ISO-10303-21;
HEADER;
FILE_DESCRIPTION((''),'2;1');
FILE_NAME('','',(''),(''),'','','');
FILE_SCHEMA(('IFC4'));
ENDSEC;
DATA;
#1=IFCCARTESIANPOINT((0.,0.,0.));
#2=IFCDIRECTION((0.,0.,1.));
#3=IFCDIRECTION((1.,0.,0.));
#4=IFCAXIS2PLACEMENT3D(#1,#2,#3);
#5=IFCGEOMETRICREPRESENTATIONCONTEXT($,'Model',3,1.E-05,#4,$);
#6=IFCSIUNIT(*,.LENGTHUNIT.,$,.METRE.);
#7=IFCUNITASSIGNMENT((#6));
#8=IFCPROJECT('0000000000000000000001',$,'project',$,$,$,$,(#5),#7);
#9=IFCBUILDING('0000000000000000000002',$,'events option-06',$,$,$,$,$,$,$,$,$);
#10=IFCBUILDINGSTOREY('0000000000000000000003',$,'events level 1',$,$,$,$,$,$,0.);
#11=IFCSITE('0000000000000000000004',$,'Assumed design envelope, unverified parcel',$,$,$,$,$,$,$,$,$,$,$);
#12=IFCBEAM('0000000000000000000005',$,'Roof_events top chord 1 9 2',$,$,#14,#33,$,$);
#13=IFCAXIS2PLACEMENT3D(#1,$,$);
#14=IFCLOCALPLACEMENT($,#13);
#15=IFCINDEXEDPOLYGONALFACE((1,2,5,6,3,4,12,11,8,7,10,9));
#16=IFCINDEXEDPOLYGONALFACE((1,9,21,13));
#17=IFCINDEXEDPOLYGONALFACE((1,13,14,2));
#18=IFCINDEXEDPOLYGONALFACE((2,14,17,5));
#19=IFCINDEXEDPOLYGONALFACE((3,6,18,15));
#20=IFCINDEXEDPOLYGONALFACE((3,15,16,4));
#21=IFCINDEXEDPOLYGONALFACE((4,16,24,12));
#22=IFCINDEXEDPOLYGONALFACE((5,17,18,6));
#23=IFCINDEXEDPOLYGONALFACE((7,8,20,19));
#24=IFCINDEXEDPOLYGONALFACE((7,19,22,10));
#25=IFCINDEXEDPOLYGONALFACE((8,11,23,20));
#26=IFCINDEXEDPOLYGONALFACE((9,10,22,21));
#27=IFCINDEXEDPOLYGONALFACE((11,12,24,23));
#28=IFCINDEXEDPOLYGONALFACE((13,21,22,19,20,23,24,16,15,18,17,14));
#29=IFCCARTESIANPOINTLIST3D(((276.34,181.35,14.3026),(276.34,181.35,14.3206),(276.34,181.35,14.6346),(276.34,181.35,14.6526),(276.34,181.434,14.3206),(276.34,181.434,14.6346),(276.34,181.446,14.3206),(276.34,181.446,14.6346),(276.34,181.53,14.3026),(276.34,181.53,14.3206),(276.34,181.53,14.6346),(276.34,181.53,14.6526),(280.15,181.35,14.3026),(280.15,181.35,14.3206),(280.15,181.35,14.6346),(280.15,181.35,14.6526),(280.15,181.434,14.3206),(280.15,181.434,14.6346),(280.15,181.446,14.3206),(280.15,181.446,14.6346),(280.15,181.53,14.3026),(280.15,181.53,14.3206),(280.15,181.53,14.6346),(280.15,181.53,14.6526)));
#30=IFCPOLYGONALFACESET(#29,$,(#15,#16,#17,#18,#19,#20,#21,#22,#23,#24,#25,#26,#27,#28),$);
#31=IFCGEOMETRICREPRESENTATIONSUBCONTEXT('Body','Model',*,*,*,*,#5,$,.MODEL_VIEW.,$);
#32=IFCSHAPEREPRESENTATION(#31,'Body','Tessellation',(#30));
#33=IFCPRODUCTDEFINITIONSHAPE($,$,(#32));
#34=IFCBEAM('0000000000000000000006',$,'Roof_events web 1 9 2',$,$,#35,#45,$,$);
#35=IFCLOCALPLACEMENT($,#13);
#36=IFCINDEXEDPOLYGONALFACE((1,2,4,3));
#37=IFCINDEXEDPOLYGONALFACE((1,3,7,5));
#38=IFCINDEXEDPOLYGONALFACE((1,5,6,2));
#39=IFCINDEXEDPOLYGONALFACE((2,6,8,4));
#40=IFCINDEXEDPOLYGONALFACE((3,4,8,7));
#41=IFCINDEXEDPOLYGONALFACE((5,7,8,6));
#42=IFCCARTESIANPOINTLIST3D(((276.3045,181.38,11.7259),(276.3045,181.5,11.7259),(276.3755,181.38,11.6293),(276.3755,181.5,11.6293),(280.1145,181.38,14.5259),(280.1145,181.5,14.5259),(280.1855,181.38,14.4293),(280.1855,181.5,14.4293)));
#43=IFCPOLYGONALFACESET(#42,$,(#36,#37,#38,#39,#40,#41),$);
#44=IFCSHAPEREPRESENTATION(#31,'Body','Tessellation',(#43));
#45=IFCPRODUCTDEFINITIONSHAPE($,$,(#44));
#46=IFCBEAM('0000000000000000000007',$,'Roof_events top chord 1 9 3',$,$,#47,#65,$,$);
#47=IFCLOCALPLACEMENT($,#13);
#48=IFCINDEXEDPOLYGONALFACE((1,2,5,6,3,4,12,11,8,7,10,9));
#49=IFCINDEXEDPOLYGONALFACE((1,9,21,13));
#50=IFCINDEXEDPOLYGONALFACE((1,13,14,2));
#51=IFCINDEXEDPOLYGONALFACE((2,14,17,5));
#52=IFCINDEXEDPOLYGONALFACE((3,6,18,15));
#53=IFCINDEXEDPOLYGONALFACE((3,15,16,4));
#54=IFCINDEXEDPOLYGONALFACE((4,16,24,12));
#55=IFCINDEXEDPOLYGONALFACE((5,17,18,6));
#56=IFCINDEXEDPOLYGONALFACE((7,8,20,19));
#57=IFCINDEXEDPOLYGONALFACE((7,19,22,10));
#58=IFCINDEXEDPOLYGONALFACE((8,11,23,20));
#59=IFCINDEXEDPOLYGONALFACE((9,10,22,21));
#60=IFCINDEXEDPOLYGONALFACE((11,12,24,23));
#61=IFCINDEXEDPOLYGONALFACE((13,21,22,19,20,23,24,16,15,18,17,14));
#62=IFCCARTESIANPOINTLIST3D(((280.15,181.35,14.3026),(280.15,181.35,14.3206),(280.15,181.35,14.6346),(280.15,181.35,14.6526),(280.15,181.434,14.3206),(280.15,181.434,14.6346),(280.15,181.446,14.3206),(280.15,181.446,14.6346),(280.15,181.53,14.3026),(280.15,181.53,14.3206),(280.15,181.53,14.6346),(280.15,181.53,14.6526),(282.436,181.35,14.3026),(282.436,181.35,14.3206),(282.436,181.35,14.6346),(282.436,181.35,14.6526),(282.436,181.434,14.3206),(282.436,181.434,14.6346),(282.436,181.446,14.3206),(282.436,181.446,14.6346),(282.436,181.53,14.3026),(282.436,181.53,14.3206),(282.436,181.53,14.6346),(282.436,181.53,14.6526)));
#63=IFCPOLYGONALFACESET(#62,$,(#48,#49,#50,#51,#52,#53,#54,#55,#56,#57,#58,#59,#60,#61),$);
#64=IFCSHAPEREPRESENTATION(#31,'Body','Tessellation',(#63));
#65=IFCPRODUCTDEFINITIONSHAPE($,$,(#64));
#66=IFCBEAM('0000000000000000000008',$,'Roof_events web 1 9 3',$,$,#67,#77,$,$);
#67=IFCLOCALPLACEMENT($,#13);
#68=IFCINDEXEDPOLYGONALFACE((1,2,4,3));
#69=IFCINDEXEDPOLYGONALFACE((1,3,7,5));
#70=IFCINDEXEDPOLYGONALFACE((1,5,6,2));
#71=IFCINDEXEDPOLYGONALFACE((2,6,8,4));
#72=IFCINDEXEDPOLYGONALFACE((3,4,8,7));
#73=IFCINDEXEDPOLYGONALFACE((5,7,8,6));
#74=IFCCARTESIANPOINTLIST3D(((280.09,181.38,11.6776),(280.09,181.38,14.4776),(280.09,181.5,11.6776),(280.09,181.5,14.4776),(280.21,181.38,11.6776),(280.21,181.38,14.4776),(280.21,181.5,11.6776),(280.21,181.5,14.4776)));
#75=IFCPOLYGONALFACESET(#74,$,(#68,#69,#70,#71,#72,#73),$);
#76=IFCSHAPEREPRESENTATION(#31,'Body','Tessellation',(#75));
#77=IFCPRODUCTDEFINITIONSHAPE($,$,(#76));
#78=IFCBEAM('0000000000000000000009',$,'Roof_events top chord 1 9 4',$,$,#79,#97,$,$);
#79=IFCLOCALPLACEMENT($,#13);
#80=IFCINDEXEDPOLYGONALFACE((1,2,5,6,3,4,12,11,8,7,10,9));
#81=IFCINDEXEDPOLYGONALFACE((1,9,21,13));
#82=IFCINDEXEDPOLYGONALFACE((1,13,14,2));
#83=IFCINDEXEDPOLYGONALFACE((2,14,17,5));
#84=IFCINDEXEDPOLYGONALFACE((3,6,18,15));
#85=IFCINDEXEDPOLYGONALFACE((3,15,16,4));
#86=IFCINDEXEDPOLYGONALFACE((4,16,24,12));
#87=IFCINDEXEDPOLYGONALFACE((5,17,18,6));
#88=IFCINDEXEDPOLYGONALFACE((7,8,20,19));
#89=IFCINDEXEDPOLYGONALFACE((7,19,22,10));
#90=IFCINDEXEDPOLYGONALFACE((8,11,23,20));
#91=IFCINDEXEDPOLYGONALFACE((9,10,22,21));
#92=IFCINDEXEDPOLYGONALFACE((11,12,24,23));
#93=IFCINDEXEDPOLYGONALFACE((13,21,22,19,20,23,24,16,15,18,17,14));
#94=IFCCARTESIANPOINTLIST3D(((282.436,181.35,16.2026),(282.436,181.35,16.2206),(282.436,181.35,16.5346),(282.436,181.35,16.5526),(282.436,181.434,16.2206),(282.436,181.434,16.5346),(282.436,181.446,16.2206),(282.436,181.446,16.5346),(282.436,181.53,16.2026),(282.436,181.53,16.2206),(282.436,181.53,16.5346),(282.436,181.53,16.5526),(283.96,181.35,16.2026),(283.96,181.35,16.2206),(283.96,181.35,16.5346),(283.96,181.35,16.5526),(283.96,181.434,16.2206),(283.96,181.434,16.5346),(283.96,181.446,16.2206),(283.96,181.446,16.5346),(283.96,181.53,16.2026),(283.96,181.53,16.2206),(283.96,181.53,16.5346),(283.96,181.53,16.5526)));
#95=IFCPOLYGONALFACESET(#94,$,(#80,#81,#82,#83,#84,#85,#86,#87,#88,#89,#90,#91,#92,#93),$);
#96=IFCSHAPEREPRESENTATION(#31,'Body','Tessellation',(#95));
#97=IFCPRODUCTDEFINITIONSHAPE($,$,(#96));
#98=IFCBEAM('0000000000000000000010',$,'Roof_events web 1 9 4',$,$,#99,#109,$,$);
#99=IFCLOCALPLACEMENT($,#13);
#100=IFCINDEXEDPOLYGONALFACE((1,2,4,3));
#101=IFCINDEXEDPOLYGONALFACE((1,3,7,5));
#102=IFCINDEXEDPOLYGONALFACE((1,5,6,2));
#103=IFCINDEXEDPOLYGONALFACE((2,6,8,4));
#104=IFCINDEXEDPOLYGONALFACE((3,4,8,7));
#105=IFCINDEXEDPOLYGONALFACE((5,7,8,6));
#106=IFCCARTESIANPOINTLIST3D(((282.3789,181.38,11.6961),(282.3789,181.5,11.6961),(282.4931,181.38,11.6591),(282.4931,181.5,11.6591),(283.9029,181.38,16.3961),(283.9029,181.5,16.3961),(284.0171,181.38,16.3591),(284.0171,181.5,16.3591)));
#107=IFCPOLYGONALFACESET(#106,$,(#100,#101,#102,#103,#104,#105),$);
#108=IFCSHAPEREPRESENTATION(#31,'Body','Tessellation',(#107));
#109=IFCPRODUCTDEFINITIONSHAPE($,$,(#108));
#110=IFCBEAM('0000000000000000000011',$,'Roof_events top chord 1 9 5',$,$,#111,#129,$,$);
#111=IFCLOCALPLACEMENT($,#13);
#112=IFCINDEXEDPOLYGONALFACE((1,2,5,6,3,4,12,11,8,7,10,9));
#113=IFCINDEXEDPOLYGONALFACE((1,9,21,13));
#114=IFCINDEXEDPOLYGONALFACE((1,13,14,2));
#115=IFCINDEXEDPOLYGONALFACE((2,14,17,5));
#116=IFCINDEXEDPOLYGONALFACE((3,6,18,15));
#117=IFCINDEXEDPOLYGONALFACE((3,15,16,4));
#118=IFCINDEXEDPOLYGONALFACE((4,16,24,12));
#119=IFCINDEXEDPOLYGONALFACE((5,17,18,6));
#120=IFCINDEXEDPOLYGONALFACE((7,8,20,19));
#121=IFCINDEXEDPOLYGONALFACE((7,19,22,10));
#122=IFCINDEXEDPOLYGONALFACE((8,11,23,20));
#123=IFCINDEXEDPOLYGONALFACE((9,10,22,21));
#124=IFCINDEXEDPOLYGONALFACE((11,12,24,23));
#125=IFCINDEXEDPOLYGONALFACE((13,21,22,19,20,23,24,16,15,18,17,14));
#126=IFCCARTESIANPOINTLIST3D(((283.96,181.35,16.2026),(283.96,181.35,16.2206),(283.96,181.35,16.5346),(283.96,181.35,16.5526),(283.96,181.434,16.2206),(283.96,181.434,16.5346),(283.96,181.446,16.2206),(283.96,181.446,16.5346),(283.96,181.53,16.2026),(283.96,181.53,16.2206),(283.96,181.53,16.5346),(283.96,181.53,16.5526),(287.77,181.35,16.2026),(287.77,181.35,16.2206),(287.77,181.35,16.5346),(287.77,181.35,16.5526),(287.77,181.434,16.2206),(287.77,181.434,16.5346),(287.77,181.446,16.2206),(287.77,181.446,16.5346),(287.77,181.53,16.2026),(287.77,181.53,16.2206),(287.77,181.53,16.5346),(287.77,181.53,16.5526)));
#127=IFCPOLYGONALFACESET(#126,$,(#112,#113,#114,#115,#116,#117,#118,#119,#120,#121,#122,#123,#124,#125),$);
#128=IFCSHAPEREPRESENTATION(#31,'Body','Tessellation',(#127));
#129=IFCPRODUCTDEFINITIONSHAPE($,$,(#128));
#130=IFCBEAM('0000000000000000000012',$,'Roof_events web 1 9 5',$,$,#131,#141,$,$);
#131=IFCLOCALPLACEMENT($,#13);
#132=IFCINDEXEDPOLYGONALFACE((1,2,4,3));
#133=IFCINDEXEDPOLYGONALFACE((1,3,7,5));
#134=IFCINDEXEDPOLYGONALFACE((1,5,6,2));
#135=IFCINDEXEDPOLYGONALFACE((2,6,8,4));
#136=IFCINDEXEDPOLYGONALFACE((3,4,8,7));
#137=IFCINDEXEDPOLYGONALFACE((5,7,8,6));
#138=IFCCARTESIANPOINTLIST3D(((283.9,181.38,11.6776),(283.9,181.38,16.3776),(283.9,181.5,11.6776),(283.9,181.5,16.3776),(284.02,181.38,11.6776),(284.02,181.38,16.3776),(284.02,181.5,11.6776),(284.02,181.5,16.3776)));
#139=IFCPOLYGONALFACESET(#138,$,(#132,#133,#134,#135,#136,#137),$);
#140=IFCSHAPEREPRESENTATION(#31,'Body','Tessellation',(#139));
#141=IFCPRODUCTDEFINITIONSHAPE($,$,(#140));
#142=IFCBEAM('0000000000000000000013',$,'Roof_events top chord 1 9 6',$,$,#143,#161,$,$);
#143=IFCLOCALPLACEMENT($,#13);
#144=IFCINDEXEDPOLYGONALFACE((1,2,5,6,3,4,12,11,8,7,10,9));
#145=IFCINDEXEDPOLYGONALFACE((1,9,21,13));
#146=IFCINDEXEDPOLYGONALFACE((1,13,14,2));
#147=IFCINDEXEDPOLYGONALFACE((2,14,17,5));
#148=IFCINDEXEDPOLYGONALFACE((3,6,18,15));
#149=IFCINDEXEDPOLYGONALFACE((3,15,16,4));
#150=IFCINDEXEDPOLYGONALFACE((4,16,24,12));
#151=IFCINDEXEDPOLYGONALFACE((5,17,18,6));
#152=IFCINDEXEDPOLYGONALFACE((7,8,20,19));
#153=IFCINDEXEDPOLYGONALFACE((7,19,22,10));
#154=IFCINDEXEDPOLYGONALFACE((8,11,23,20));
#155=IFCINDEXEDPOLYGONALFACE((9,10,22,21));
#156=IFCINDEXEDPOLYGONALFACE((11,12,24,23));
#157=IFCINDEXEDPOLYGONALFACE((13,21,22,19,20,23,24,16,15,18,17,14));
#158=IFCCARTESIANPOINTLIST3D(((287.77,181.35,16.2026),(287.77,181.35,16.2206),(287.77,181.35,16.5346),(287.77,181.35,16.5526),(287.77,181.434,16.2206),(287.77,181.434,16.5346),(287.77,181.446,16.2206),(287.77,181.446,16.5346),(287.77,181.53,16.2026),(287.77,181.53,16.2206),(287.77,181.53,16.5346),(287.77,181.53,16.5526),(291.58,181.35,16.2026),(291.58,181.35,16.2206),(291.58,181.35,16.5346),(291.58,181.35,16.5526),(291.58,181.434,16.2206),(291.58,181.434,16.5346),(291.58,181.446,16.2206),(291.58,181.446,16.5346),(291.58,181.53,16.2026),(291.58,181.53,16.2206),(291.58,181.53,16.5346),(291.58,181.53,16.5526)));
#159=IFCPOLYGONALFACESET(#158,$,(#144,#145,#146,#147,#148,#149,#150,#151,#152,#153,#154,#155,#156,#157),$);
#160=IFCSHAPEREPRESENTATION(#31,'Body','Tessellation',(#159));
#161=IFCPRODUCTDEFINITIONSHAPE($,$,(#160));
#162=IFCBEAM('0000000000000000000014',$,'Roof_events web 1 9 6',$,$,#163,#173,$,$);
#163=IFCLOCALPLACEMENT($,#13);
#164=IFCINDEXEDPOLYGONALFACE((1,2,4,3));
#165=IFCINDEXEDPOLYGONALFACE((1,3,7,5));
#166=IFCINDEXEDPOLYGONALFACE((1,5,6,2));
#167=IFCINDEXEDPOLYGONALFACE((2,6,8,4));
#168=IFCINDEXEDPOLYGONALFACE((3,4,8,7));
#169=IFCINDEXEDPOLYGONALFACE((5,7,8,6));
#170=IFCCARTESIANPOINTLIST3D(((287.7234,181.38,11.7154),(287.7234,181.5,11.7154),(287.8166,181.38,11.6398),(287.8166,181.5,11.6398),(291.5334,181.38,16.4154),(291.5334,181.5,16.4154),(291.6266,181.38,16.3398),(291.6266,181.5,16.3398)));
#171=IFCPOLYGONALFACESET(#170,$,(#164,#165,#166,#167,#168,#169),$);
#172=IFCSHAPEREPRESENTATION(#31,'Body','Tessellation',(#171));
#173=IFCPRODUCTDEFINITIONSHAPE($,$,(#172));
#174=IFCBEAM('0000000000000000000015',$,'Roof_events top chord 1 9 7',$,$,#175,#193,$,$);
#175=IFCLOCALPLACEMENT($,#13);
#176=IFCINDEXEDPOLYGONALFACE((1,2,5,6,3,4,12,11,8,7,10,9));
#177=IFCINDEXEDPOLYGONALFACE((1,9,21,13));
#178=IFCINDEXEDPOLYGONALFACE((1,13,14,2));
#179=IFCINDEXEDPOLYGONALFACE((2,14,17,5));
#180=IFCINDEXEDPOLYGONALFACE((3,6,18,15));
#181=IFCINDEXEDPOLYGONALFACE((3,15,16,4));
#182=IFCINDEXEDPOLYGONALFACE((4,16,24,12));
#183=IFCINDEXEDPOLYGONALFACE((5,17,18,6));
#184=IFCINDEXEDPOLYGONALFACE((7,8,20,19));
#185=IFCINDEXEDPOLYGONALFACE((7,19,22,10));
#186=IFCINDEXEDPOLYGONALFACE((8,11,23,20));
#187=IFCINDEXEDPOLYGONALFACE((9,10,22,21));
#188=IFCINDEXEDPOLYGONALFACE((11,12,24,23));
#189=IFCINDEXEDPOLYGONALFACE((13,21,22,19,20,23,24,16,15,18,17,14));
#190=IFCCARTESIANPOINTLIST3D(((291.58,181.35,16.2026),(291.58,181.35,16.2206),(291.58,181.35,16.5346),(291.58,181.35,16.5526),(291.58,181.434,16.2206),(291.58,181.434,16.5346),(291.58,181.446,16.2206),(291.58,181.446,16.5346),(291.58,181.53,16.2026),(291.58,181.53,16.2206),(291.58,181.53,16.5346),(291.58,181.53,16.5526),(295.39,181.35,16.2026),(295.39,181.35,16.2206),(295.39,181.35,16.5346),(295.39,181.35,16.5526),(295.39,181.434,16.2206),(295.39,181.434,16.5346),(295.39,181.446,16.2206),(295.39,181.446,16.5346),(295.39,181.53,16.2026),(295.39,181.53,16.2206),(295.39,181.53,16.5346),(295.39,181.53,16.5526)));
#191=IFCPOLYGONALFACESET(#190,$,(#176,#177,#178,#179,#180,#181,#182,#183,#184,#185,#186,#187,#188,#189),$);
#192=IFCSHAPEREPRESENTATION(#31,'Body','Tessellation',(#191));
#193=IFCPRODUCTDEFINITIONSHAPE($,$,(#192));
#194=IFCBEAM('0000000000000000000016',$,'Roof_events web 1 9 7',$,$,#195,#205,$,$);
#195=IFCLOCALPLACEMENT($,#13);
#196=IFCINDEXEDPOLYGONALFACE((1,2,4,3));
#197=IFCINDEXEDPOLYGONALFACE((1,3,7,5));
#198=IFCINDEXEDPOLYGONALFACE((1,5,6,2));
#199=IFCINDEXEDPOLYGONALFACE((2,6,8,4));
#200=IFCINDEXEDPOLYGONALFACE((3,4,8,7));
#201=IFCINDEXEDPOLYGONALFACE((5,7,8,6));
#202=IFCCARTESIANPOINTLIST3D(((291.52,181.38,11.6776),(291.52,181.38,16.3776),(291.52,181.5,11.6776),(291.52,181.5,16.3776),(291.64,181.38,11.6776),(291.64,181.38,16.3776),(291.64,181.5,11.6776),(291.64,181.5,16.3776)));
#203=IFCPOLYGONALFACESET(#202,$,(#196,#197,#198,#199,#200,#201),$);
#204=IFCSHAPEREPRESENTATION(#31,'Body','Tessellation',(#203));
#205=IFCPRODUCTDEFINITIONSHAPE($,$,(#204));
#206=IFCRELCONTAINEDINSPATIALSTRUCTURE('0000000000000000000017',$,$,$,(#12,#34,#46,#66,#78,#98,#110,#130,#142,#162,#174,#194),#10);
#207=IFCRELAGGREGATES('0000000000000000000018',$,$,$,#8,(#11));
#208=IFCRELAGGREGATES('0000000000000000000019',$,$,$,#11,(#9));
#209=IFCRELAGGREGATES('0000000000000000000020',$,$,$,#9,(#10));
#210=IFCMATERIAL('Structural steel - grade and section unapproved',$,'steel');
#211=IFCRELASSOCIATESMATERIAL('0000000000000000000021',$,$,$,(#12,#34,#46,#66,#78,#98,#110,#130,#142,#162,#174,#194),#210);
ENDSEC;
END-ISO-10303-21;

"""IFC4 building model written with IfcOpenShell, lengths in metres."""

from ifc_helpers import new_model, si_unit, frame, origin_with_axes, place, context, subcontext, project, spatial, rectangle, i_section, extrude, material, element, save


model = new_model("IFC4")

# Units and contexts
model_context = context("Model", 3, precision=1e-05, world=origin_with_axes())
body_context = subcontext(model_context, "Body", "Model", "MODEL_VIEW")
ifc_project = project(units=[si_unit("LENGTHUNIT", "METRE")], contexts=[model_context])

# Site, building, storey
site = spatial("IfcSite", under=ifc_project, Name="Assumed design envelope, unverified parcel")
building = spatial("IfcBuilding", under=site, Name="events option-06")
storey = spatial("IfcBuildingStorey", under=building, Name="events level 1", Elevation=0.0)

# Beams
ifc_material_1 = material(Name="Structural steel - grade and section unapproved", Category="steel")
beam_1_placement = place(None, frame((276.34, 181.44, 14.4776), z_axis=(1.0, 0.0, 0.0), x_axis=(0.0, 1.0, 0.0)))
element("IfcBeam", 1, at=beam_1_placement, inside=storey, material=ifc_material_1, Name="Roof_events top chord 1 9 2", context=body_context, shape_type="SweptSolid", body=[
    extrude(i_section(OverallWidth=0.18, OverallDepth=0.35, WebThickness=0.012, FlangeThickness=0.018, FilletRadius=0.0), origin_with_axes(), (0.0, 0.0, 1.0), 3.81),
])
beam_2_placement = place(None, frame((276.34, 181.44, 11.6776), z_axis=(0.805799, 0.0, 0.592189), x_axis=(0.0, 1.0, 0.0)))
element("IfcBeam", 2, at=beam_2_placement, inside=storey, material=ifc_material_1, Name="Roof_events web 1 9 2", context=body_context, shape_type="SweptSolid", body=[
    extrude(rectangle(XDim=0.12, YDim=0.12), origin_with_axes(), (0.0, 0.0, 1.0), 4.7282),
])
beam_3_placement = place(None, frame((280.15, 181.44, 14.4776), z_axis=(1.0, 0.0, 0.0), x_axis=(0.0, 1.0, 0.0)))
element("IfcBeam", 3, at=beam_3_placement, inside=storey, material=ifc_material_1, Name="Roof_events top chord 1 9 3", context=body_context, shape_type="SweptSolid", body=[
    extrude(i_section(OverallWidth=0.18, OverallDepth=0.35, WebThickness=0.012, FlangeThickness=0.018, FilletRadius=0.0), origin_with_axes(), (0.0, 0.0, 1.0), 2.286),
])
beam_4_placement = place(None, frame((280.15, 181.44, 11.6776), z_axis=(0.0, 0.0, 1.0), x_axis=(-1.0, 0.0, 0.0)))
element("IfcBeam", 4, at=beam_4_placement, inside=storey, material=ifc_material_1, Name="Roof_events web 1 9 3", context=body_context, shape_type="SweptSolid", body=[
    extrude(rectangle(XDim=0.12, YDim=0.12), origin_with_axes(), (0.0, 0.0, 1.0), 2.8),
])
beam_5_placement = place(None, frame((282.436, 181.44, 16.3776), z_axis=(1.0, 0.0, 0.0), x_axis=(0.0, 1.0, 0.0)))
element("IfcBeam", 5, at=beam_5_placement, inside=storey, material=ifc_material_1, Name="Roof_events top chord 1 9 4", context=body_context, shape_type="SweptSolid", body=[
    extrude(i_section(OverallWidth=0.18, OverallDepth=0.35, WebThickness=0.012, FlangeThickness=0.018, FilletRadius=0.0), origin_with_axes(), (0.0, 0.0, 1.0), 1.524),
])
beam_6_placement = place(None, frame((282.436, 181.44, 11.6776), z_axis=(0.308443, 0.0, 0.951243), x_axis=(0.0, 1.0, 0.0)))
element("IfcBeam", 6, at=beam_6_placement, inside=storey, material=ifc_material_1, Name="Roof_events web 1 9 4", context=body_context, shape_type="SweptSolid", body=[
    extrude(rectangle(XDim=0.12, YDim=0.12), origin_with_axes(), (0.0, 0.0, 1.0), 4.9409),
])
beam_7_placement = place(None, frame((283.96, 181.44, 16.3776), z_axis=(1.0, 0.0, 0.0), x_axis=(0.0, 1.0, 0.0)))
element("IfcBeam", 7, at=beam_7_placement, inside=storey, material=ifc_material_1, Name="Roof_events top chord 1 9 5", context=body_context, shape_type="SweptSolid", body=[
    extrude(i_section(OverallWidth=0.18, OverallDepth=0.35, WebThickness=0.012, FlangeThickness=0.018, FilletRadius=0.0), origin_with_axes(), (0.0, 0.0, 1.0), 3.81),
])
beam_8_placement = place(None, frame((283.96, 181.44, 11.6776), z_axis=(0.0, 0.0, 1.0), x_axis=(-1.0, 0.0, 0.0)))
element("IfcBeam", 8, at=beam_8_placement, inside=storey, material=ifc_material_1, Name="Roof_events web 1 9 5", context=body_context, shape_type="SweptSolid", body=[
    extrude(rectangle(XDim=0.12, YDim=0.12), origin_with_axes(), (0.0, 0.0, 1.0), 4.7),
])
beam_9_placement = place(None, frame((287.77, 181.44, 16.3776), z_axis=(1.0, 0.0, 0.0), x_axis=(0.0, 1.0, 0.0)))
element("IfcBeam", 9, at=beam_9_placement, inside=storey, material=ifc_material_1, Name="Roof_events top chord 1 9 6", context=body_context, shape_type="SweptSolid", body=[
    extrude(i_section(OverallWidth=0.18, OverallDepth=0.35, WebThickness=0.012, FlangeThickness=0.018, FilletRadius=0.0), origin_with_axes(), (0.0, 0.0, 1.0), 3.81),
])
beam_10_placement = place(None, frame((287.77, 181.44, 11.6776), z_axis=(0.629721, 0.0, 0.776821), x_axis=(0.0, 1.0, 0.0)))
element("IfcBeam", 10, at=beam_10_placement, inside=storey, material=ifc_material_1, Name="Roof_events web 1 9 6", context=body_context, shape_type="SweptSolid", body=[
    extrude(rectangle(XDim=0.12, YDim=0.12), origin_with_axes(), (0.0, 0.0, 1.0), 6.0503),
])
beam_11_placement = place(None, frame((291.58, 181.44, 16.3776), z_axis=(1.0, 0.0, 0.0), x_axis=(0.0, 1.0, 0.0)))
element("IfcBeam", 11, at=beam_11_placement, inside=storey, material=ifc_material_1, Name="Roof_events top chord 1 9 7", context=body_context, shape_type="SweptSolid", body=[
    extrude(i_section(OverallWidth=0.18, OverallDepth=0.35, WebThickness=0.012, FlangeThickness=0.018, FilletRadius=0.0), origin_with_axes(), (0.0, 0.0, 1.0), 3.81),
])
beam_12_placement = place(None, frame((291.58, 181.44, 11.6776), z_axis=(0.0, 0.0, 1.0), x_axis=(-1.0, 0.0, 0.0)))
element("IfcBeam", 12, at=beam_12_placement, inside=storey, material=ifc_material_1, Name="Roof_events web 1 9 7", context=body_context, shape_type="SweptSolid", body=[
    extrude(rectangle(XDim=0.12, YDim=0.12), origin_with_axes(), (0.0, 0.0, 1.0), 4.7),
])

save(model, "model.ifc")
